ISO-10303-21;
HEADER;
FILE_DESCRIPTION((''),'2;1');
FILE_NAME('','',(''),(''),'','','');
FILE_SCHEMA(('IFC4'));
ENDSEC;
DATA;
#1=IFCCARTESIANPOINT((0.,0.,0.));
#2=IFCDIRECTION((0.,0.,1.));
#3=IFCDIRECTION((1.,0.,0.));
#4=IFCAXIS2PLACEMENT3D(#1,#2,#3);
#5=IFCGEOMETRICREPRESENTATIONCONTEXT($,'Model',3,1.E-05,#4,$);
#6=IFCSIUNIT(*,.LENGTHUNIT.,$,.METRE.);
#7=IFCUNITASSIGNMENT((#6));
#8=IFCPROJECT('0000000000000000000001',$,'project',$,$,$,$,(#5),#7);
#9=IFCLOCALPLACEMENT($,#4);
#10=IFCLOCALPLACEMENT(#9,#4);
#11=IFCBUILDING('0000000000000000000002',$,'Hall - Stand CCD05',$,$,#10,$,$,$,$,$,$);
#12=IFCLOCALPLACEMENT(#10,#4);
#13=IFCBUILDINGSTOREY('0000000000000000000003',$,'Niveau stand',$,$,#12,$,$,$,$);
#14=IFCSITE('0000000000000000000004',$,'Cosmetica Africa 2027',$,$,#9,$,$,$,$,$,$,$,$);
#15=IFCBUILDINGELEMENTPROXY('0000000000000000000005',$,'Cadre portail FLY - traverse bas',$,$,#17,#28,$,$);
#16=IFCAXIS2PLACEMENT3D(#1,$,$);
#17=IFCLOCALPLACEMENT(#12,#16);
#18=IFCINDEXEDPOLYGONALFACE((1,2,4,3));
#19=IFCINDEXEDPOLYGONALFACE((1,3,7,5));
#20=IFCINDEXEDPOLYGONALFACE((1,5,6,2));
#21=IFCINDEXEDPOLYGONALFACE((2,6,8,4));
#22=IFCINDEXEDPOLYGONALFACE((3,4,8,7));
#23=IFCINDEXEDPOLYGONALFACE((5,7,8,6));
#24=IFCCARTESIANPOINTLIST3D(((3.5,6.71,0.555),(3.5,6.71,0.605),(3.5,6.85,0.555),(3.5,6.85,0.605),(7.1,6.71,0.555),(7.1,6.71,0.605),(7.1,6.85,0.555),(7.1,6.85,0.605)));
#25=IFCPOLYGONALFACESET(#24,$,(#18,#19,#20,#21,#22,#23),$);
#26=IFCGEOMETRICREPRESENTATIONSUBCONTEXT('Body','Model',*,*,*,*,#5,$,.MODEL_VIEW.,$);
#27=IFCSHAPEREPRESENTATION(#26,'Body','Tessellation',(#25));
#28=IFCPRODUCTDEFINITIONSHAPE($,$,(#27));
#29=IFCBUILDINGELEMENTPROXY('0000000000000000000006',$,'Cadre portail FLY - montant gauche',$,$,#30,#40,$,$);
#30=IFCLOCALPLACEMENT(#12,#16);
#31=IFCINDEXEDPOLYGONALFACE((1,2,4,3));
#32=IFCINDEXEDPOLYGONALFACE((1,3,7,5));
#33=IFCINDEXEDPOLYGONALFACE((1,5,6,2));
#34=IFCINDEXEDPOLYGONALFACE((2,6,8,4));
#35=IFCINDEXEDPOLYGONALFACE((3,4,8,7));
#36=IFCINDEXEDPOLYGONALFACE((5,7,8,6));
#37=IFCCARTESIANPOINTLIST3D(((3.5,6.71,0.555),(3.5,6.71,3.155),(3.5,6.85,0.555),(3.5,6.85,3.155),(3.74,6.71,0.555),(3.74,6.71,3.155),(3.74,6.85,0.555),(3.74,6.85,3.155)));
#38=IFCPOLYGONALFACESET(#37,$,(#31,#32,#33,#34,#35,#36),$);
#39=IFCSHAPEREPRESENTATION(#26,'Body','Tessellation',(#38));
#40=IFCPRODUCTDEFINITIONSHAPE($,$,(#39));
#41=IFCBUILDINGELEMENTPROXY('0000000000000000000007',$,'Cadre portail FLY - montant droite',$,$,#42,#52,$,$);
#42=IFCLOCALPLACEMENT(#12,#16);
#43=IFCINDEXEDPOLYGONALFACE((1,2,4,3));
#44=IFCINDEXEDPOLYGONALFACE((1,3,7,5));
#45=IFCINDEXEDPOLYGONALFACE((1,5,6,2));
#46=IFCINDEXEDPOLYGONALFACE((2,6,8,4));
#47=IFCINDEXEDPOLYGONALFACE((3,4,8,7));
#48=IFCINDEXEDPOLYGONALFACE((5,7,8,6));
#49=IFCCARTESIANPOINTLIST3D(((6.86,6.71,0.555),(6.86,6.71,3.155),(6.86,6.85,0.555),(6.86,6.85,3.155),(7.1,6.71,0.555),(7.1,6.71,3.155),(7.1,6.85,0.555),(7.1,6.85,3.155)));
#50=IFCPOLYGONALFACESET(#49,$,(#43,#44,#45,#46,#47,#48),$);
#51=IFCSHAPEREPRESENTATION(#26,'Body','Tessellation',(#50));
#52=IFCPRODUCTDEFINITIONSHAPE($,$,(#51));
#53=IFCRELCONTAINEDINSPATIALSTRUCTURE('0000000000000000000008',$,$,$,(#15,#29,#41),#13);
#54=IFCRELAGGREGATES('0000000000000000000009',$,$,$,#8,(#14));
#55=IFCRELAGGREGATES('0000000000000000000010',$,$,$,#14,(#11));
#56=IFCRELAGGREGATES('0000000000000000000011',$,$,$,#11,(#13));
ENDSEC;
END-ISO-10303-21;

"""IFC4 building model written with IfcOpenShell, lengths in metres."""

from ifc_helpers import new_model, si_unit, frame, origin_with_axes, place, context, subcontext, project, spatial, polyline, outline, extrude, element, save


model = new_model("IFC4")

# Units and contexts
model_context = context("Model", 3, precision=1e-05, world=origin_with_axes())
body_context = subcontext(model_context, "Body", "Model", "MODEL_VIEW")
ifc_project = project(units=[si_unit("LENGTHUNIT", "METRE")], contexts=[model_context])

# Site, building, storey
site_placement = place(None, origin_with_axes())
site = spatial("IfcSite", under=ifc_project, at=site_placement, Name="Cosmetica Africa 2027")
building_placement = place(site_placement, origin_with_axes())
building = spatial("IfcBuilding", under=site, at=building_placement, Name="Hall - Stand CCD05")
storey_placement = place(building_placement, origin_with_axes())
storey = spatial("IfcBuildingStorey", under=building, at=storey_placement, Name="Niveau stand")

# Building element proxies
proxy_1_placement = place(storey_placement, origin_with_axes())
element("IfcBuildingElementProxy", 1, at=proxy_1_placement, inside=storey, Name="Cadre portail FLY - traverse bas", context=body_context, shape_type="SweptSolid", body=[
    extrude(outline(polyline([(3.5, 6.71), (7.1, 6.71), (7.1, 6.85), (3.5, 6.85), (3.5, 6.71)])), frame((0.0, 0.0, 0.555)), (0.0, 0.0, 1.0), 0.05),
])
proxy_2_placement = place(storey_placement, origin_with_axes())
element("IfcBuildingElementProxy", 2, at=proxy_2_placement, inside=storey, Name="Cadre portail FLY - montant gauche", context=body_context, shape_type="SweptSolid", body=[
    extrude(outline(polyline([(3.5, 6.71), (3.74, 6.71), (3.74, 6.85), (3.5, 6.85), (3.5, 6.71)])), frame((0.0, 0.0, 0.555)), (0.0, 0.0, 1.0), 2.6),
])
proxy_3_placement = place(storey_placement, origin_with_axes())
element("IfcBuildingElementProxy", 3, at=proxy_3_placement, inside=storey, Name="Cadre portail FLY - montant droite", context=body_context, shape_type="SweptSolid", body=[
    extrude(outline(polyline([(6.86, 6.71), (7.1, 6.71), (7.1, 6.85), (6.86, 6.85), (6.86, 6.71)])), frame((0.0, 0.0, 0.555)), (0.0, 0.0, 1.0), 2.6),
])

save(model, "model.ifc")
